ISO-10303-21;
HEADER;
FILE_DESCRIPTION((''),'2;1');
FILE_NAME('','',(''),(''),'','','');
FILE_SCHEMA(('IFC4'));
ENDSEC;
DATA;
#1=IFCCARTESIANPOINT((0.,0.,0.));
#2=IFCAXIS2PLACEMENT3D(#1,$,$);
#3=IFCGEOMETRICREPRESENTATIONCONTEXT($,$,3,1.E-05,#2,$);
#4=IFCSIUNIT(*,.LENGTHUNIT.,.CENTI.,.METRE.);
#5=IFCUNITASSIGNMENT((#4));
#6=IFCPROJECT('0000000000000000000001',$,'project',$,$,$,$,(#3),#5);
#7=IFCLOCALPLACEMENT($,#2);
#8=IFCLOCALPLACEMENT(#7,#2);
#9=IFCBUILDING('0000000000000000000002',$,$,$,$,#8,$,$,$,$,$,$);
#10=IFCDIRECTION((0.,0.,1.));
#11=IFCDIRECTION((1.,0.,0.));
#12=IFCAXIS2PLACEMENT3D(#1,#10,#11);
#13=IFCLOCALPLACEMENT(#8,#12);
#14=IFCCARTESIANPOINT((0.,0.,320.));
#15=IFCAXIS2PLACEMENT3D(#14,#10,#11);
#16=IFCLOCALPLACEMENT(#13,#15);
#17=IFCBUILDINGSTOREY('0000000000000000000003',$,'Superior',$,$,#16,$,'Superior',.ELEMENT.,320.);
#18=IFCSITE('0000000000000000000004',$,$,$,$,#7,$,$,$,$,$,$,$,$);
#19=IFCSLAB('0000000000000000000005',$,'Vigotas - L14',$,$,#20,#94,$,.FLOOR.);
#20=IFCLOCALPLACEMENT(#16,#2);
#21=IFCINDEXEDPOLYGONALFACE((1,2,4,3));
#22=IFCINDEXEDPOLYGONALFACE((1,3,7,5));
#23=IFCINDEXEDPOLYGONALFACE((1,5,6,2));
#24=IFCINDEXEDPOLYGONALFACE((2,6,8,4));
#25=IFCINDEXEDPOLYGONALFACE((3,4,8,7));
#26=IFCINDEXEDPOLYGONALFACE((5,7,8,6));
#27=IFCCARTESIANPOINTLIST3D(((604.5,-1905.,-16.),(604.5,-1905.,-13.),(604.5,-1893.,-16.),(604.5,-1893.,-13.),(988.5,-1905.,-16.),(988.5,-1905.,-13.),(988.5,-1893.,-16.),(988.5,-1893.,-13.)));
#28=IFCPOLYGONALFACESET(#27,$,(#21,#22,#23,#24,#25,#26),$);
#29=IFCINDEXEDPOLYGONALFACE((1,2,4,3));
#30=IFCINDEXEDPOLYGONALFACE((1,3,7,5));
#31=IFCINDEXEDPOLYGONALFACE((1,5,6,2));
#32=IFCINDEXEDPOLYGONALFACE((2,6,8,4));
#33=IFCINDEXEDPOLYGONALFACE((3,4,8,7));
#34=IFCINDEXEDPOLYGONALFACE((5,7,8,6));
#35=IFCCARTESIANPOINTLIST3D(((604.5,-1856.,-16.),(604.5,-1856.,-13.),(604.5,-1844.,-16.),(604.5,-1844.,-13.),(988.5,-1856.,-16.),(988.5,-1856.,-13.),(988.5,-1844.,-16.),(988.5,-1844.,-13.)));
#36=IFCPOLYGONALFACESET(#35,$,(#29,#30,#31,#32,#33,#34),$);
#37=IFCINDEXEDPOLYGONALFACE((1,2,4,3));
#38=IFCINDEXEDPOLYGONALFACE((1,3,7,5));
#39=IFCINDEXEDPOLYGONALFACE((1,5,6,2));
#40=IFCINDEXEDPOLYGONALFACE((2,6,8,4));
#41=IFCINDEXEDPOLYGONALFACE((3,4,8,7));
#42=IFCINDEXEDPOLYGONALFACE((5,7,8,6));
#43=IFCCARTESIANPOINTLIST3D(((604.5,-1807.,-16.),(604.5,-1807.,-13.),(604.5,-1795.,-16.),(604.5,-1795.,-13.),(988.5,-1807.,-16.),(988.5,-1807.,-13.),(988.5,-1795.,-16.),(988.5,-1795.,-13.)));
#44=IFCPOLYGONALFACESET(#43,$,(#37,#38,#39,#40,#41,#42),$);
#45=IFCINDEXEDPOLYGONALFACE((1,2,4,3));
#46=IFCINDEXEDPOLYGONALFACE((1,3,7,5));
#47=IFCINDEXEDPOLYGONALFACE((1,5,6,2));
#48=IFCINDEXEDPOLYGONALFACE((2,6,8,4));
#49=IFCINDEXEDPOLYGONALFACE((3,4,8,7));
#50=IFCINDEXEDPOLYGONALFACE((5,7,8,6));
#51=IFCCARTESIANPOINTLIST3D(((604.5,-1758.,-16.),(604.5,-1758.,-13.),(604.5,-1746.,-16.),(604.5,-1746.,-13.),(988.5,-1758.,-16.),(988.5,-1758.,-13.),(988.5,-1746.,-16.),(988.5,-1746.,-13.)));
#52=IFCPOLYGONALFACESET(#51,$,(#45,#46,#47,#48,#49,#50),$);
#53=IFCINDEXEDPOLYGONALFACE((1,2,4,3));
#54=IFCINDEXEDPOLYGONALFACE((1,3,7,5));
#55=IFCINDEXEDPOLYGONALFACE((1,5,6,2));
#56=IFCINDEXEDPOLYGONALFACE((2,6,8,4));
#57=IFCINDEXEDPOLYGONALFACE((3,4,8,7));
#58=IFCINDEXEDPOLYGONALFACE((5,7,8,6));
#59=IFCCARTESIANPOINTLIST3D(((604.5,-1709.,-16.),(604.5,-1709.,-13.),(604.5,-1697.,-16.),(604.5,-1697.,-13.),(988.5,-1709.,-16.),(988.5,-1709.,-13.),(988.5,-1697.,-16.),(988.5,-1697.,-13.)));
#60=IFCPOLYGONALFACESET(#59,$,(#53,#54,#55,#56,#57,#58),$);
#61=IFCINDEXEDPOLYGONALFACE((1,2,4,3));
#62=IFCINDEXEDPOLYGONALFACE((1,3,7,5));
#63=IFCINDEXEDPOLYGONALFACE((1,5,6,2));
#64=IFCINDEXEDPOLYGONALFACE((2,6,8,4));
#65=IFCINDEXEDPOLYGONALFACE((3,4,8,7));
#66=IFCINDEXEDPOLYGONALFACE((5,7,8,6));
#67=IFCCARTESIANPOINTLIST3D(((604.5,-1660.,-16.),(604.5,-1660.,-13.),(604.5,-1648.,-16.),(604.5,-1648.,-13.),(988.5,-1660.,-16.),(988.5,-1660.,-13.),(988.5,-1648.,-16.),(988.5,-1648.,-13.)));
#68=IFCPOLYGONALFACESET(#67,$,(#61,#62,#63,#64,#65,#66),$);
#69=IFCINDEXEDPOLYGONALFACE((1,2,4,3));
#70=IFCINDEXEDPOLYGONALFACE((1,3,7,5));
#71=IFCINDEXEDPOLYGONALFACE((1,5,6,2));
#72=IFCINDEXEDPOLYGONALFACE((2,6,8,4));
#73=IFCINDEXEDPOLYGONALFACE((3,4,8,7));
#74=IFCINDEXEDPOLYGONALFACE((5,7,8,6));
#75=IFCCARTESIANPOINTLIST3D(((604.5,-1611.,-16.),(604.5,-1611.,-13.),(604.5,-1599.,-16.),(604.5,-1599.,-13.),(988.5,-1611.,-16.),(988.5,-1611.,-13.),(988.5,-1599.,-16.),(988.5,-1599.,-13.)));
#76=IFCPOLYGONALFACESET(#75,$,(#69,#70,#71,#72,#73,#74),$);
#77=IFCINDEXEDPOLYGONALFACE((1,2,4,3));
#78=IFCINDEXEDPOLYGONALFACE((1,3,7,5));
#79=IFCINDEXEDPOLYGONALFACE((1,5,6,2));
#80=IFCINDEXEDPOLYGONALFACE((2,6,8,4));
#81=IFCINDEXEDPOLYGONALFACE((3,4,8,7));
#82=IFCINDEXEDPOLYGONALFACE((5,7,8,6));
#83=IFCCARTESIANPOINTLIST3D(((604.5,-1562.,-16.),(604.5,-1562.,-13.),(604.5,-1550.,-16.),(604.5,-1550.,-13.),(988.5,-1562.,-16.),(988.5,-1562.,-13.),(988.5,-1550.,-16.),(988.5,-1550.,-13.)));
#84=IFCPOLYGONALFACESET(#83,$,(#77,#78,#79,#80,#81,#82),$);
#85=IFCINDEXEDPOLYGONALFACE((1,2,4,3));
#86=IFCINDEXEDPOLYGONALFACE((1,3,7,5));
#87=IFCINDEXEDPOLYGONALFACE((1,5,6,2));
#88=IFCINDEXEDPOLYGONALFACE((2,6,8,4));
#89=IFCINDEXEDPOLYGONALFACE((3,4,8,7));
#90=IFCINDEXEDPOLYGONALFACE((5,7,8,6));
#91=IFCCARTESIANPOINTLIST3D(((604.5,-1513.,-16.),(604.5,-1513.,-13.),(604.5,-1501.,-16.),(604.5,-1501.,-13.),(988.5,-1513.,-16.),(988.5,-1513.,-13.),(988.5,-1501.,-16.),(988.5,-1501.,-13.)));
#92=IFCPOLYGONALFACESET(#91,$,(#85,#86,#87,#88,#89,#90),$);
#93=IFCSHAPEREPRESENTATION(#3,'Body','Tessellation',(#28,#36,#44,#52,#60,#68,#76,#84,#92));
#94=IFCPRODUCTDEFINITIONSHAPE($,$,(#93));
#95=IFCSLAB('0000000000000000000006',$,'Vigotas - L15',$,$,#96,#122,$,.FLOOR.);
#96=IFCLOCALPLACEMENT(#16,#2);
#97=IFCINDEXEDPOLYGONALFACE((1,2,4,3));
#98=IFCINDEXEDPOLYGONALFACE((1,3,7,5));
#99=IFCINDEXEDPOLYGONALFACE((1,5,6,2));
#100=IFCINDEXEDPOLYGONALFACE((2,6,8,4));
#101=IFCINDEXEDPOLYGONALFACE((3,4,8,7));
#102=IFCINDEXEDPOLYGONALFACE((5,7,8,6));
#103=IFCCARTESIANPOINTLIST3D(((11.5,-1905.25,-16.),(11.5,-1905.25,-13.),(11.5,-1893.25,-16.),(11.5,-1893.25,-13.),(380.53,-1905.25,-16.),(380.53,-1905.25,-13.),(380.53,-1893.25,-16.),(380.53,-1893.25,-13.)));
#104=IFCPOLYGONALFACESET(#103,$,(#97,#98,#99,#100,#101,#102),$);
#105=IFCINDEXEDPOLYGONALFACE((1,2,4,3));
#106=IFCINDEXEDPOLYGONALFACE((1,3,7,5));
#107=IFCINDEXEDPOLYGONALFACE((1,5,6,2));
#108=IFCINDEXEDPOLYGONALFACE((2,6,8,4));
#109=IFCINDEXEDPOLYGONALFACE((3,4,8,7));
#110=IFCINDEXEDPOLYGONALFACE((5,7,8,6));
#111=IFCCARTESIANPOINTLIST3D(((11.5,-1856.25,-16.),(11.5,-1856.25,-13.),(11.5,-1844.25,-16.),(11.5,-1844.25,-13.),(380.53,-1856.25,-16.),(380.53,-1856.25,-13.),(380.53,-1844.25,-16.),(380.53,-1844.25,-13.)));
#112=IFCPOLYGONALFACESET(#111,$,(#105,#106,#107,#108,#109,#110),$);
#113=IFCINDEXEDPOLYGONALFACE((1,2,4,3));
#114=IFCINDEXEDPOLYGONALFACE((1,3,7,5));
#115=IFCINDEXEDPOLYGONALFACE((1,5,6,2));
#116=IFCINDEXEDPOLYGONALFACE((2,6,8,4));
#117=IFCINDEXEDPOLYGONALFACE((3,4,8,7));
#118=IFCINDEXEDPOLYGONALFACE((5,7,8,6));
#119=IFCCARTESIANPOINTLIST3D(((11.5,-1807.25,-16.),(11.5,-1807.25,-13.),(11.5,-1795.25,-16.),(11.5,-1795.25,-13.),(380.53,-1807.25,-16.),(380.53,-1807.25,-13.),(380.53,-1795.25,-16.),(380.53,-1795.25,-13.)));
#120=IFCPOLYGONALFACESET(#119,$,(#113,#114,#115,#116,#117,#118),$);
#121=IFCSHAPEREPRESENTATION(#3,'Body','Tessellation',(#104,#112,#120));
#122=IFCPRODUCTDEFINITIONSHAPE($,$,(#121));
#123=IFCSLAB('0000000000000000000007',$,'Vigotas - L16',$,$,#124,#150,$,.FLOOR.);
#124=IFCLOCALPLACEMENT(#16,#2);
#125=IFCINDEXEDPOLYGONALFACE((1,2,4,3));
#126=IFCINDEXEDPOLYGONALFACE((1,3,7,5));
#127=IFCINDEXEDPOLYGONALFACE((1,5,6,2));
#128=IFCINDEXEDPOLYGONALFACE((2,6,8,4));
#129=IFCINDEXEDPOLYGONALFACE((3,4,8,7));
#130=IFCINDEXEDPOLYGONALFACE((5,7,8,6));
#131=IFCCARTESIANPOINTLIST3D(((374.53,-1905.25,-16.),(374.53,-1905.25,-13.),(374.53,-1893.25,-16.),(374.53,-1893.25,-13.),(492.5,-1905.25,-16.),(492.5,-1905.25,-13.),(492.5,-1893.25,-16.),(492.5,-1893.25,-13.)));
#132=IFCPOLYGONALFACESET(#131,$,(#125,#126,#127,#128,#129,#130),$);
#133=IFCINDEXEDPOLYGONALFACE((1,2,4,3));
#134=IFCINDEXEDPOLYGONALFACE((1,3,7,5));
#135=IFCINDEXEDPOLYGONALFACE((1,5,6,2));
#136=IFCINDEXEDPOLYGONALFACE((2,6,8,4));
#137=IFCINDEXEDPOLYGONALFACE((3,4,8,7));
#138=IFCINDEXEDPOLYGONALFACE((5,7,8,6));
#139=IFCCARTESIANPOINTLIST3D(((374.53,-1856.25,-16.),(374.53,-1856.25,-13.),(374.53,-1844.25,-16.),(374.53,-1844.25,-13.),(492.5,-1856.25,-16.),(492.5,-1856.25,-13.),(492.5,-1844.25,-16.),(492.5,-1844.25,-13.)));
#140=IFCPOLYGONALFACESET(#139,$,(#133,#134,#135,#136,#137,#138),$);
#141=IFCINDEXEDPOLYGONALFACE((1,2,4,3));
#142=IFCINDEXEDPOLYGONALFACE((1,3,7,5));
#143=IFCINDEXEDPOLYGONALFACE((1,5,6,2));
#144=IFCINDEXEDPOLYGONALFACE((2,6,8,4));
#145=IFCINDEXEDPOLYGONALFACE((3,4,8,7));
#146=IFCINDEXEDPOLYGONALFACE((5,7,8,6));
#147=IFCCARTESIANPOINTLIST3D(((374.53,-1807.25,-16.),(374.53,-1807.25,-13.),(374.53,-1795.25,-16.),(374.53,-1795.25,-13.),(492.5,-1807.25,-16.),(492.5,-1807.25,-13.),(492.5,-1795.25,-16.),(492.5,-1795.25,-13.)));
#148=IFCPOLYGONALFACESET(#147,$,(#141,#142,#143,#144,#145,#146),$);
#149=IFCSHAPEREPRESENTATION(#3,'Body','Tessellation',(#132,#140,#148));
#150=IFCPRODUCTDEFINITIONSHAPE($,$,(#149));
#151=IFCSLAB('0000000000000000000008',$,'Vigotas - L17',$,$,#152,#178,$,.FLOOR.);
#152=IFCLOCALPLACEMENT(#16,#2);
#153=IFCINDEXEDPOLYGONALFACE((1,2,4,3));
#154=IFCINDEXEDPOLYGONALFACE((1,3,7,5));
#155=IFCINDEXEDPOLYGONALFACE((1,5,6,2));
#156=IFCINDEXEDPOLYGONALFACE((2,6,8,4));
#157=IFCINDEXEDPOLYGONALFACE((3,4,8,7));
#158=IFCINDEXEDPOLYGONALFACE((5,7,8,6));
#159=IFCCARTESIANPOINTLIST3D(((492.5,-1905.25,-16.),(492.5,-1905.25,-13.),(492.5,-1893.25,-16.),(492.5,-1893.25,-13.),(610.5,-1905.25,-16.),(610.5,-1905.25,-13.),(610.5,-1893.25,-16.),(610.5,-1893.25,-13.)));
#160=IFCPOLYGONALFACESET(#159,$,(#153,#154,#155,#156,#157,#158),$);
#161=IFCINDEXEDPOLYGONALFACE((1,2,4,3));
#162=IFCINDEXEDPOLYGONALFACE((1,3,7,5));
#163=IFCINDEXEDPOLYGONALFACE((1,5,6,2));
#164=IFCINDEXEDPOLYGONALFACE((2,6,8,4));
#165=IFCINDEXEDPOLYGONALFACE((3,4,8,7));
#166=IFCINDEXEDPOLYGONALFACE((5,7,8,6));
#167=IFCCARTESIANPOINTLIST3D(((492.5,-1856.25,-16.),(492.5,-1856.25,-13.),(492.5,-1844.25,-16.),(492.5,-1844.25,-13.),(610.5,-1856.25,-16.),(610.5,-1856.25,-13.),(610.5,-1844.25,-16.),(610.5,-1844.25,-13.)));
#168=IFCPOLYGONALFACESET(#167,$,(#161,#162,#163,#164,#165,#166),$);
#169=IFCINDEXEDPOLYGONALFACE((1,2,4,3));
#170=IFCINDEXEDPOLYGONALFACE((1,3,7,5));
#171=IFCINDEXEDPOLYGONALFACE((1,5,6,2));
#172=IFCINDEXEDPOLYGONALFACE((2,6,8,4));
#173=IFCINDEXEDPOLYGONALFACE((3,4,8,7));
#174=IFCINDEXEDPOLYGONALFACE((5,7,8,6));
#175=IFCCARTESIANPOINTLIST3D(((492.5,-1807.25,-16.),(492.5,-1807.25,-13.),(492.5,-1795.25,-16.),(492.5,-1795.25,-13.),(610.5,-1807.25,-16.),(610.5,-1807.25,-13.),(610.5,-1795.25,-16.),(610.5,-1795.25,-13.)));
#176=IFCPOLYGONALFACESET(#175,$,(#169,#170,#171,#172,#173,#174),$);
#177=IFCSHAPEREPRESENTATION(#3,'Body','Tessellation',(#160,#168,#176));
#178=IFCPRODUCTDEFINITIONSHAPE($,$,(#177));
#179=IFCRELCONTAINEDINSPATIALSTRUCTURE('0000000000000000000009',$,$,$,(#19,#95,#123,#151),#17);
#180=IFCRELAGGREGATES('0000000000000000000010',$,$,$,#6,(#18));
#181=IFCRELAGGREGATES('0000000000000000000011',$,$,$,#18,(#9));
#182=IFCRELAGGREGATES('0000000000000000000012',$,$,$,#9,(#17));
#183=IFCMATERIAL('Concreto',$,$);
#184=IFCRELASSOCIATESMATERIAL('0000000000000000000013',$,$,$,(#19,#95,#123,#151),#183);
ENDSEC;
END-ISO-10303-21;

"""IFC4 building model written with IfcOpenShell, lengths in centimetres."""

from ifc_helpers import new_model, si_unit, frame, origin, origin_with_axes, place, context, project, spatial, polyline, outline, extrude, material, element, save


model = new_model("IFC4")

# Units and contexts
context_of_model = context(None, 3, precision=1e-05, world=origin())
ifc_project = project(units=[si_unit("LENGTHUNIT", "METRE", prefix="CENTI")], contexts=[context_of_model])

# Site, building, storey
site_placement = place(None, origin())
site = spatial("IfcSite", under=ifc_project, at=site_placement)
building_placement = place(site_placement, origin())
building = spatial("IfcBuilding", under=site, at=building_placement)
placement = place(building_placement, origin_with_axes())
storey_placement = place(placement, frame((0.0, 0.0, 320.0), z_axis=(0.0, 0.0, 1.0), x_axis=(1.0, 0.0, 0.0)))
storey = spatial("IfcBuildingStorey", under=building, at=storey_placement, Name="Superior", LongName="Superior", CompositionType="ELEMENT", Elevation=320.0)

# Shared definitions
ifc_material = material(Name="Concreto")

# Slabs
slab_1_placement = place(storey_placement, frame((796.5, -1703.0, -13.0), z_axis=(0.0, 0.0, 1.0), x_axis=(1.0, 0.0, 0.0)))
element("IfcSlab", 1, at=slab_1_placement, inside=storey, material=ifc_material, Name="Vigotas - L14", PredefinedType="FLOOR", context=context_of_model, shape_type="SolidModel", body=[
    extrude(outline(polyline([(6.0, 1.5), (-6.0, 1.5), (-6.0, -1.5), (6.0, -1.5), (6.0, 1.5), (6.0, 1.5)])), frame((-192.0, -196.0, -1.5), z_axis=(1.0, 0.0, 0.0), x_axis=(0.0, -1.0, 0.0)), (0.0, 0.0, 1.0), 384.0),
    extrude(outline(polyline([(6.0, 1.5), (-6.0, 1.5), (-6.0, -1.5), (6.0, -1.5), (6.0, 1.5), (6.0, 1.5)])), frame((-192.0, -147.0, -1.5), z_axis=(1.0, 0.0, 0.0), x_axis=(0.0, -1.0, 0.0)), (0.0, 0.0, 1.0), 384.0),
    extrude(outline(polyline([(6.0, 1.5), (-6.0, 1.5), (-6.0, -1.5), (6.0, -1.5), (6.0, 1.5), (6.0, 1.5)])), frame((-192.0, -98.0, -1.5), z_axis=(1.0, 0.0, 0.0), x_axis=(0.0, -1.0, 0.0)), (0.0, 0.0, 1.0), 384.0),
    extrude(outline(polyline([(6.0, 1.5), (-6.0, 1.5), (-6.0, -1.5), (6.0, -1.5), (6.0, 1.5), (6.0, 1.5)])), frame((-192.0, -49.0, -1.5), z_axis=(1.0, 0.0, 0.0), x_axis=(0.0, -1.0, 0.0)), (0.0, 0.0, 1.0), 384.0),
    extrude(outline(polyline([(6.0, 1.5), (-6.0, 1.5), (-6.0, -1.5), (6.0, -1.5), (6.0, 1.5), (6.0, 1.5)])), frame((-192.0, 0.0, -1.5), z_axis=(1.0, 0.0, 0.0), x_axis=(0.0, -1.0, 0.0)), (0.0, 0.0, 1.0), 384.0),
    extrude(outline(polyline([(6.0, 1.5), (-6.0, 1.5), (-6.0, -1.5), (6.0, -1.5), (6.0, 1.5), (6.0, 1.5)])), frame((-192.0, 49.0, -1.5), z_axis=(1.0, 0.0, 0.0), x_axis=(0.0, -1.0, 0.0)), (0.0, 0.0, 1.0), 384.0),
    extrude(outline(polyline([(6.0, 1.5), (-6.0, 1.5), (-6.0, -1.5), (6.0, -1.5), (6.0, 1.5), (6.0, 1.5)])), frame((-192.0, 98.0, -1.5), z_axis=(1.0, 0.0, 0.0), x_axis=(0.0, -1.0, 0.0)), (0.0, 0.0, 1.0), 384.0),
    extrude(outline(polyline([(6.0, 1.5), (-6.0, 1.5), (-6.0, -1.5), (6.0, -1.5), (6.0, 1.5), (6.0, 1.5)])), frame((-192.0, 147.0, -1.5), z_axis=(1.0, 0.0, 0.0), x_axis=(0.0, -1.0, 0.0)), (0.0, 0.0, 1.0), 384.0),
    extrude(outline(polyline([(6.0, 1.5), (-6.0, 1.5), (-6.0, -1.5), (6.0, -1.5), (6.0, 1.5), (6.0, 1.5)])), frame((-192.0, 196.0, -1.5), z_axis=(1.0, 0.0, 0.0), x_axis=(0.0, -1.0, 0.0)), (0.0, 0.0, 1.0), 384.0),
])
slab_2_placement = place(storey_placement, frame((196.01, -1850.25, -13.0), z_axis=(0.0, 0.0, 1.0), x_axis=(1.0, 0.0, 0.0)))
element("IfcSlab", 2, at=slab_2_placement, inside=storey, material=ifc_material, Name="Vigotas - L15", PredefinedType="FLOOR", context=context_of_model, shape_type="SolidModel", body=[
    extrude(outline(polyline([(6.0, 1.5), (-6.0, 1.5), (-6.0, -1.5), (6.0, -1.5), (6.0, 1.5), (6.0, 1.5)])), frame((-184.51, -49.0, -1.5), z_axis=(1.0, 0.0, 0.0), x_axis=(0.0, -1.0, 0.0)), (0.0, 0.0, 1.0), 369.03),
    extrude(outline(polyline([(6.0, 1.5), (-6.0, 1.5), (-6.0, -1.5), (6.0, -1.5), (6.0, 1.5), (6.0, 1.5)])), frame((-184.51, 0.0, -1.5), z_axis=(1.0, 0.0, 0.0), x_axis=(0.0, -1.0, 0.0)), (0.0, 0.0, 1.0), 369.03),
    extrude(outline(polyline([(6.0, 1.5), (-6.0, 1.5), (-6.0, -1.5), (6.0, -1.5), (6.0, 1.5), (6.0, 1.5)])), frame((-184.51, 49.0, -1.5), z_axis=(1.0, 0.0, 0.0), x_axis=(0.0, -1.0, 0.0)), (0.0, 0.0, 1.0), 369.03),
])
slab_3_placement = place(storey_placement, frame((433.51, -1850.25, -13.0), z_axis=(0.0, 0.0, 1.0), x_axis=(1.0, 0.0, 0.0)))
element("IfcSlab", 3, at=slab_3_placement, inside=storey, material=ifc_material, Name="Vigotas - L16", PredefinedType="FLOOR", context=context_of_model, shape_type="SolidModel", body=[
    extrude(outline(polyline([(6.0, 1.5), (-6.0, 1.5), (-6.0, -1.5), (6.0, -1.5), (6.0, 1.5), (6.0, 1.5)])), frame((-58.98, -49.0, -1.5), z_axis=(1.0, 0.0, 0.0), x_axis=(0.0, -1.0, 0.0)), (0.0, 0.0, 1.0), 117.97),
    extrude(outline(polyline([(6.0, 1.5), (-6.0, 1.5), (-6.0, -1.5), (6.0, -1.5), (6.0, 1.5), (6.0, 1.5)])), frame((-58.98, 0.0, -1.5), z_axis=(1.0, 0.0, 0.0), x_axis=(0.0, -1.0, 0.0)), (0.0, 0.0, 1.0), 117.97),
    extrude(outline(polyline([(6.0, 1.5), (-6.0, 1.5), (-6.0, -1.5), (6.0, -1.5), (6.0, 1.5), (6.0, 1.5)])), frame((-58.98, 49.0, -1.5), z_axis=(1.0, 0.0, 0.0), x_axis=(0.0, -1.0, 0.0)), (0.0, 0.0, 1.0), 117.97),
])
slab_4_placement = place(storey_placement, frame((551.5, -1850.25, -13.0), z_axis=(0.0, 0.0, 1.0), x_axis=(1.0, 0.0, 0.0)))
element("IfcSlab", 4, at=slab_4_placement, inside=storey, material=ifc_material, Name="Vigotas - L17", PredefinedType="FLOOR", context=context_of_model, shape_type="SolidModel", body=[
    extrude(outline(polyline([(6.0, 1.5), (-6.0, 1.5), (-6.0, -1.5), (6.0, -1.5), (6.0, 1.5), (6.0, 1.5)])), frame((-59.0, -49.0, -1.5), z_axis=(1.0, 0.0, 0.0), x_axis=(0.0, -1.0, 0.0)), (0.0, 0.0, 1.0), 118.0),
    extrude(outline(polyline([(6.0, 1.5), (-6.0, 1.5), (-6.0, -1.5), (6.0, -1.5), (6.0, 1.5), (6.0, 1.5)])), frame((-59.0, 0.0, -1.5), z_axis=(1.0, 0.0, 0.0), x_axis=(0.0, -1.0, 0.0)), (0.0, 0.0, 1.0), 118.0),
    extrude(outline(polyline([(6.0, 1.5), (-6.0, 1.5), (-6.0, -1.5), (6.0, -1.5), (6.0, 1.5), (6.0, 1.5)])), frame((-59.0, 49.0, -1.5), z_axis=(1.0, 0.0, 0.0), x_axis=(0.0, -1.0, 0.0)), (0.0, 0.0, 1.0), 118.0),
])

save(model, "model.ifc")
